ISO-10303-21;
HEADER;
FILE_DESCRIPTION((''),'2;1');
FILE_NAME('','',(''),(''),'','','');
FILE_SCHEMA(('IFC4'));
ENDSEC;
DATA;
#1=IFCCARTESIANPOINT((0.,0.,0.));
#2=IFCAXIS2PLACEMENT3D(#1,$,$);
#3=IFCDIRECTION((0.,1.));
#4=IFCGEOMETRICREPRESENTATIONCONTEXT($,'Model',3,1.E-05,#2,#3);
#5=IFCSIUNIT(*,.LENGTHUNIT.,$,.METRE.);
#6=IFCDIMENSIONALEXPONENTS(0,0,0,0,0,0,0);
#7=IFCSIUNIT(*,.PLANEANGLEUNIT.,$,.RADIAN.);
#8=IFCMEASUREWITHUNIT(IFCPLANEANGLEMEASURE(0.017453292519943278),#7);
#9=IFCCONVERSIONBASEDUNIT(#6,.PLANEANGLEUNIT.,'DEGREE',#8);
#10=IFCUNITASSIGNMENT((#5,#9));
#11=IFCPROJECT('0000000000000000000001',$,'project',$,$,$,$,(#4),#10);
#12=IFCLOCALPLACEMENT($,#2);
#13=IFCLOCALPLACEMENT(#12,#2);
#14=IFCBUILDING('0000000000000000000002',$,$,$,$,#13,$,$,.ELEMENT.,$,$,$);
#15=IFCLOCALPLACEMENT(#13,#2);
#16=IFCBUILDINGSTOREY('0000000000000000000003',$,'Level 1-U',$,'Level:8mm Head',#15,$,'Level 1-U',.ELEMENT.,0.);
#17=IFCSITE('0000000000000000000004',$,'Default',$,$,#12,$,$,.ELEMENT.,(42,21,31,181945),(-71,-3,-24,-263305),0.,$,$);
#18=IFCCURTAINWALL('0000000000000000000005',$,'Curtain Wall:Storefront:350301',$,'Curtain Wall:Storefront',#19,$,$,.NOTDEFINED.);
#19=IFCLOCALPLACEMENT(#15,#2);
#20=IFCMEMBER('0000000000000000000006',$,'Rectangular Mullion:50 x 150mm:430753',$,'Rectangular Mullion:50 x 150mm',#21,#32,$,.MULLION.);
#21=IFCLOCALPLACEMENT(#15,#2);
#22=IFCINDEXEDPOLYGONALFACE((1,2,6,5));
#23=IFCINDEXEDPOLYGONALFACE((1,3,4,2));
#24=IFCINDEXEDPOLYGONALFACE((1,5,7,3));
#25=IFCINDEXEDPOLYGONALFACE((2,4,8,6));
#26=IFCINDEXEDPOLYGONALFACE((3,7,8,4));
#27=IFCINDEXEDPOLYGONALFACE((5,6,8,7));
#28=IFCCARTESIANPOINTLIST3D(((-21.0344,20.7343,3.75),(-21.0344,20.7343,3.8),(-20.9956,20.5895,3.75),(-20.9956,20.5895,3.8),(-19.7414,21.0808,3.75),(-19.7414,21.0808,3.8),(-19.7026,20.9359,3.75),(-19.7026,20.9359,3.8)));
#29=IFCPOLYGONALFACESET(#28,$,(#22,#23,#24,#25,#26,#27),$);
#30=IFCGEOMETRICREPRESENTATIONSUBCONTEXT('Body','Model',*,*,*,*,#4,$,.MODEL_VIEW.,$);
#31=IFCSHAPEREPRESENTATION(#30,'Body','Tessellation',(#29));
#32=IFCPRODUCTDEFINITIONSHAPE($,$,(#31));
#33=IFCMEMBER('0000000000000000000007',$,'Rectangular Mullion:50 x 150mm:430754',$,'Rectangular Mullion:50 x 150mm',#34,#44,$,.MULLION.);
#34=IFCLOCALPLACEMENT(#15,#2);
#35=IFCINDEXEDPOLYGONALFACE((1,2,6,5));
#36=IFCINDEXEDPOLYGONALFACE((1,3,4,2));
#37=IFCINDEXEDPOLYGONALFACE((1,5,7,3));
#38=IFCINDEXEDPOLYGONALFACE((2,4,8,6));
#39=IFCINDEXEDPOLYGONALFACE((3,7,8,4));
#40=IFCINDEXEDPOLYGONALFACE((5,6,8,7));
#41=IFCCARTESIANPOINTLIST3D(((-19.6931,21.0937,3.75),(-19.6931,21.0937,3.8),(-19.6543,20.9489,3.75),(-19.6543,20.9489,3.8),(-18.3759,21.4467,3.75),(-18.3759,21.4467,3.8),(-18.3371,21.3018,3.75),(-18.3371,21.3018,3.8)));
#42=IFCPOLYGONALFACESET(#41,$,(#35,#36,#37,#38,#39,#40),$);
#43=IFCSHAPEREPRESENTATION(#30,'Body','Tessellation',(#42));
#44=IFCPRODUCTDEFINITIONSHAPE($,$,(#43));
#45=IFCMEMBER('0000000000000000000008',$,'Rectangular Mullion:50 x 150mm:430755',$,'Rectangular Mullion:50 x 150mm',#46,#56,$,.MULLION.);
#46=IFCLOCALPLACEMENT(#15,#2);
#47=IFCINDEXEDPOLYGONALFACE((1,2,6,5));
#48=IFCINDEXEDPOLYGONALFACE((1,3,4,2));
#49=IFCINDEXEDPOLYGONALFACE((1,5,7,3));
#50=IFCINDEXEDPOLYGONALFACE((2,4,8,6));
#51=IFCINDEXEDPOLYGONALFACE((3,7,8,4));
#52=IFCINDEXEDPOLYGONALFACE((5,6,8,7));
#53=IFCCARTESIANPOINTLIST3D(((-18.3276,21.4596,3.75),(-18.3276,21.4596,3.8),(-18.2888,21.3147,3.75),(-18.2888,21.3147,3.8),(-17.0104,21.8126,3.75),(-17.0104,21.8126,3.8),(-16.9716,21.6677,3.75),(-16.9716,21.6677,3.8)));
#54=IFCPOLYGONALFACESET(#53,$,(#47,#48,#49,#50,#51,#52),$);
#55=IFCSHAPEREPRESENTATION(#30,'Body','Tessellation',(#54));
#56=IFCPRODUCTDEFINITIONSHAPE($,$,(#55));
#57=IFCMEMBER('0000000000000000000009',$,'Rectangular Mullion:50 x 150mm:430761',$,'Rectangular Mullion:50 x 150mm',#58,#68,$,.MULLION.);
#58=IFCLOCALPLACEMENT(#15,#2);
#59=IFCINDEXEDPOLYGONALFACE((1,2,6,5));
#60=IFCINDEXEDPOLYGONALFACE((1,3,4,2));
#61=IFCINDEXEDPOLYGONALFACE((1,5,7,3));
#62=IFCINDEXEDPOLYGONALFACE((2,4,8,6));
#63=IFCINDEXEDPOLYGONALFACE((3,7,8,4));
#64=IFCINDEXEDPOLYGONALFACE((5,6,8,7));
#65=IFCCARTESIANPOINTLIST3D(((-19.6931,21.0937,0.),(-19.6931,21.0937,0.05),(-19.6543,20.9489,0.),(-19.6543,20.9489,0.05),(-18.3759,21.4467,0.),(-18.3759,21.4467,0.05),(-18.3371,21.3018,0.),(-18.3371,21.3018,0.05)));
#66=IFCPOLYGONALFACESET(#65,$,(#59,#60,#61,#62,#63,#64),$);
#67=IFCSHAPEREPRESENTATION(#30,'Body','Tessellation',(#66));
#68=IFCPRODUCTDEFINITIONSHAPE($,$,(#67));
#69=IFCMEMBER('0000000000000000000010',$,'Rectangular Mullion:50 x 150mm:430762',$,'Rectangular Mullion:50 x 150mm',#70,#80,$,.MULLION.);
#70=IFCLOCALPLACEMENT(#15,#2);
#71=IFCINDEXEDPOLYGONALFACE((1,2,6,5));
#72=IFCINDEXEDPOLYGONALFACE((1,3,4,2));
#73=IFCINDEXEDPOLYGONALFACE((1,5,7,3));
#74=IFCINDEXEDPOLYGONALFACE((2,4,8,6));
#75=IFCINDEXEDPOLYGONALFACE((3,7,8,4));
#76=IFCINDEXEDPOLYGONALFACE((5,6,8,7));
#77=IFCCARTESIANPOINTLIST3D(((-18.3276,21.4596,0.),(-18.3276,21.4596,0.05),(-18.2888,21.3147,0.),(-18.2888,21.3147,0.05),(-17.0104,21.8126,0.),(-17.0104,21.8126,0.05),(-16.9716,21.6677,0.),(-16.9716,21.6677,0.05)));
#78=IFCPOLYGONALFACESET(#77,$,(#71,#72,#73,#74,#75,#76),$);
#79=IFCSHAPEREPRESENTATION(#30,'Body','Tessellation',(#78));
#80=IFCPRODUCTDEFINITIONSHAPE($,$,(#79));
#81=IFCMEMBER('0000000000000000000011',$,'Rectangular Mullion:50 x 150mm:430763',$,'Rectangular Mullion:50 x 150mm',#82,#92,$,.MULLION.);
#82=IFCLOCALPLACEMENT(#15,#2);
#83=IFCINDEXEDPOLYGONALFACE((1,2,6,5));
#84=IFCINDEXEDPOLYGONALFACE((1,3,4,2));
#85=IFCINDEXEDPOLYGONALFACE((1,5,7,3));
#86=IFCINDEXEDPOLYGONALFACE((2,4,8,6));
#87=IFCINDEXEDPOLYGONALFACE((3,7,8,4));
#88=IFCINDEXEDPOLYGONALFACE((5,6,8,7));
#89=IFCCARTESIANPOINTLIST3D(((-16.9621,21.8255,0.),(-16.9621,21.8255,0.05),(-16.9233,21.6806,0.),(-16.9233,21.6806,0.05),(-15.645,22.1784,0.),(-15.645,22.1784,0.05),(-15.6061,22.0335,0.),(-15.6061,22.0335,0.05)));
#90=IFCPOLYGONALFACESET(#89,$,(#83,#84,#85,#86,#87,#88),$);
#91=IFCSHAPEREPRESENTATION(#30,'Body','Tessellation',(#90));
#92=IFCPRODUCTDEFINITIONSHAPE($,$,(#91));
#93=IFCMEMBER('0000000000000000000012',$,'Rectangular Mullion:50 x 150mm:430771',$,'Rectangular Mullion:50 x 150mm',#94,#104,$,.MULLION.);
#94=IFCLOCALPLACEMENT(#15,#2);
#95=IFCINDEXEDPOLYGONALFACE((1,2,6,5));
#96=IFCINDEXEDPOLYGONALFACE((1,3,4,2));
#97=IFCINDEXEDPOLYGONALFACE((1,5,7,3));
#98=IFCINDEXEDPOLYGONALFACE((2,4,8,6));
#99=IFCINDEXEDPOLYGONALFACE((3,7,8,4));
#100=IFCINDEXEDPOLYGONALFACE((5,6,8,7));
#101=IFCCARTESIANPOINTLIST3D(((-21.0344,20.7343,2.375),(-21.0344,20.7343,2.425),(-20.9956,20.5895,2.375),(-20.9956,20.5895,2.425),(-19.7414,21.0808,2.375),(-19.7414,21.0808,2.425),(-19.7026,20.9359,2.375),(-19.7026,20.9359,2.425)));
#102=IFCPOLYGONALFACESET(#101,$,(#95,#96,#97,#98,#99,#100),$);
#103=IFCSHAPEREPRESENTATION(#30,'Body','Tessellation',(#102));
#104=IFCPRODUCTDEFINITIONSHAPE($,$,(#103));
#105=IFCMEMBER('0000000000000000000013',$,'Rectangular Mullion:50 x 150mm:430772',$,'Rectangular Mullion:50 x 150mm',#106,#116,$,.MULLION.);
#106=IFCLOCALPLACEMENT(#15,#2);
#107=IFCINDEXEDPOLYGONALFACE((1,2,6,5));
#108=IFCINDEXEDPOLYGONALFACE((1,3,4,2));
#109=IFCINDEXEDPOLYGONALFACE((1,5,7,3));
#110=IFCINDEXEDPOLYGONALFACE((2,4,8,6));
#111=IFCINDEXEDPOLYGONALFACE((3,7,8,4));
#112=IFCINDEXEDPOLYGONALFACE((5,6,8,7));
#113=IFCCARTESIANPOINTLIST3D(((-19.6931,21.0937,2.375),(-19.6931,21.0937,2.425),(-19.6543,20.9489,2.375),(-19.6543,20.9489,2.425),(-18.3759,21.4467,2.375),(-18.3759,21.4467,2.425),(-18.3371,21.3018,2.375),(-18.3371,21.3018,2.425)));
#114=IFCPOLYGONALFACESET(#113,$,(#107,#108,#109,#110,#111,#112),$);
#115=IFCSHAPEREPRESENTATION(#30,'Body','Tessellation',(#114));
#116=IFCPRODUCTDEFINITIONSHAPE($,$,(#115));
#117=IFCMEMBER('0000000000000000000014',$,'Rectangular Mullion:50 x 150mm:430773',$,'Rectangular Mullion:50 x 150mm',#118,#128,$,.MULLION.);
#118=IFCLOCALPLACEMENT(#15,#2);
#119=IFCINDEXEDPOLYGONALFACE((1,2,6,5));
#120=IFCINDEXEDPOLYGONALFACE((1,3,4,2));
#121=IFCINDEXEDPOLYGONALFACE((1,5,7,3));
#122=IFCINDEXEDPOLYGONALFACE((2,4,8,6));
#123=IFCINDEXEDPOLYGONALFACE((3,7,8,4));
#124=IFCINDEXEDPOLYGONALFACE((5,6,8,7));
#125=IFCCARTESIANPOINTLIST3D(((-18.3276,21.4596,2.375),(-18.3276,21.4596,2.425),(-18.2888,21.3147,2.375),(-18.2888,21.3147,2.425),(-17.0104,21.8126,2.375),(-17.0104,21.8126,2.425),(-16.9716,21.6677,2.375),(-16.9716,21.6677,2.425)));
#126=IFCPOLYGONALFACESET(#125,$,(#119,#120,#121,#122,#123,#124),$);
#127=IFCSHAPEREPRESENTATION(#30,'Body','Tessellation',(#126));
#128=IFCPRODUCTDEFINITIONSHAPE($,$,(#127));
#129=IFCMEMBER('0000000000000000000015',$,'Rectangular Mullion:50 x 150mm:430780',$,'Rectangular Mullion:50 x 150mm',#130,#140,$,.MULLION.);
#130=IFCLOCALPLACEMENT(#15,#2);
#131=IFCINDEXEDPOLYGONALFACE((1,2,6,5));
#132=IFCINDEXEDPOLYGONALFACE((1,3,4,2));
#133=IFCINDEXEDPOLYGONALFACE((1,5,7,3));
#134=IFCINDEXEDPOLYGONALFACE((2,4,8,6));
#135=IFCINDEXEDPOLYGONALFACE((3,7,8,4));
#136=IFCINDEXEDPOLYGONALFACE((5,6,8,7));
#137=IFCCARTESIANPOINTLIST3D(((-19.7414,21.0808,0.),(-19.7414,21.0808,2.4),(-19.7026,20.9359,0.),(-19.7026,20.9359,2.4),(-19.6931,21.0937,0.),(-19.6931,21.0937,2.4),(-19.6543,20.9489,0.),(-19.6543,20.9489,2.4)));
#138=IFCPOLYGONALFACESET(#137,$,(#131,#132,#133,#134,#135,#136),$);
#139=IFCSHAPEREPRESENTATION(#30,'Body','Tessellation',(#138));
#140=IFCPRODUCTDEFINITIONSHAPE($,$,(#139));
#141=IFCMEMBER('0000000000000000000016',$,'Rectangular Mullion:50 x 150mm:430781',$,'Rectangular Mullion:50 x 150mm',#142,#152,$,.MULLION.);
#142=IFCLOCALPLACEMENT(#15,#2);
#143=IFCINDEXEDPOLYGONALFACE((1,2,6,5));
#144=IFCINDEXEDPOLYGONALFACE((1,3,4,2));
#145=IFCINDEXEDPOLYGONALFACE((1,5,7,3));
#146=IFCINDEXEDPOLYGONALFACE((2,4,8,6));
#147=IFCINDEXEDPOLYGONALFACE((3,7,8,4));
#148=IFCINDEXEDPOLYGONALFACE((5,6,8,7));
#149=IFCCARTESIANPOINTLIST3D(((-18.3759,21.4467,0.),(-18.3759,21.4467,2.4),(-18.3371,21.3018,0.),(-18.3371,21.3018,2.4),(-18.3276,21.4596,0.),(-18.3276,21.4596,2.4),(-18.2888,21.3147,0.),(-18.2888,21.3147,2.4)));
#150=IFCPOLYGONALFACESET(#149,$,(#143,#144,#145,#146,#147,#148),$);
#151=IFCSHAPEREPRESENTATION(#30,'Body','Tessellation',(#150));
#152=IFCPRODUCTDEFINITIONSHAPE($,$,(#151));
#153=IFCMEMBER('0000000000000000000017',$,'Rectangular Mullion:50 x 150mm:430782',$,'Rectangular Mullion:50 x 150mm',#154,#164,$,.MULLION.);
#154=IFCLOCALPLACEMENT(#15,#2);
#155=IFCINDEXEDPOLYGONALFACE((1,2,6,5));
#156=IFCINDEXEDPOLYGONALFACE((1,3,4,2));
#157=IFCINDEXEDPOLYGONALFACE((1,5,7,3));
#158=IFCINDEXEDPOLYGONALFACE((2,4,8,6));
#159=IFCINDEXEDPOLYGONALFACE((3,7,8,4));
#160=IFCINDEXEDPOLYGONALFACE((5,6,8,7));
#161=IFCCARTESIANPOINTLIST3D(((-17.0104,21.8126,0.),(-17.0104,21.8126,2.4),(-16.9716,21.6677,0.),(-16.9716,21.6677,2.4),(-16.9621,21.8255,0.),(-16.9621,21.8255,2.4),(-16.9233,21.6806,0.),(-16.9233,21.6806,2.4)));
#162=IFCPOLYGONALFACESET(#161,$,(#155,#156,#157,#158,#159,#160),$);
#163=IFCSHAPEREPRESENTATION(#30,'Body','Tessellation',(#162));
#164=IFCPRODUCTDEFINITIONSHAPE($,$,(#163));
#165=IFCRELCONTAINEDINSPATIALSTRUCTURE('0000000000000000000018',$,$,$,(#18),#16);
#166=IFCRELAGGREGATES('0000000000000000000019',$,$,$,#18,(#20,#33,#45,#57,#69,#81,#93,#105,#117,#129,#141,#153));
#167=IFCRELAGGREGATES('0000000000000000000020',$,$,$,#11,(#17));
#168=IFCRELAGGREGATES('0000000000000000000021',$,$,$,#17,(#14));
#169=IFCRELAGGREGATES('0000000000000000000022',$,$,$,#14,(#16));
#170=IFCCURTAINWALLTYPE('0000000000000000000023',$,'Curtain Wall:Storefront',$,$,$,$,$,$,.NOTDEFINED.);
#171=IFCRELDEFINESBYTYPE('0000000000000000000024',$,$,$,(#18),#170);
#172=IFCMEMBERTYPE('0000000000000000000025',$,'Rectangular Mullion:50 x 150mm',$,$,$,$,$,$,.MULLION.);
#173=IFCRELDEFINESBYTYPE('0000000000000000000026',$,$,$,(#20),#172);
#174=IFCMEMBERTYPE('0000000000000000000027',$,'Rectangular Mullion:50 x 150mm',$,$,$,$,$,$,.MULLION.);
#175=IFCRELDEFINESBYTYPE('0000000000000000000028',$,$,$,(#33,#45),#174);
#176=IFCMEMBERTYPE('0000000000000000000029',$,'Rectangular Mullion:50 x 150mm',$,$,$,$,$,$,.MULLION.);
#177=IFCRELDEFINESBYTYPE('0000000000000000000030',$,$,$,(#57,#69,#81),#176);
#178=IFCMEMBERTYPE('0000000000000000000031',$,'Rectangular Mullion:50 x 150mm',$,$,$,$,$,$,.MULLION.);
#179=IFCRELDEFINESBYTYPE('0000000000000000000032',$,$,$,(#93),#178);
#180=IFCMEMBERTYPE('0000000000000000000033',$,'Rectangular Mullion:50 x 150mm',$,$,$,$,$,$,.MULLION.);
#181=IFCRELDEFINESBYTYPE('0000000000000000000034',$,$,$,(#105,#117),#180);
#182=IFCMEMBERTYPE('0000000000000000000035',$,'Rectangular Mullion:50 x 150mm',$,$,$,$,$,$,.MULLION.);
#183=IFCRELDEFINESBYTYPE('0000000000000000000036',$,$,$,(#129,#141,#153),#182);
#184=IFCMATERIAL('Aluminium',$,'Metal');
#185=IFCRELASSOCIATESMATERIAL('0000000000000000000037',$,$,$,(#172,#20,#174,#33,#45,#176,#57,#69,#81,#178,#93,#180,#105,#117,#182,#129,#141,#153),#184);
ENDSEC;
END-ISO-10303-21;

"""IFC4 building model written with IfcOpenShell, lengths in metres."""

from ifc_helpers import new_model, entity, si_unit, converted_unit, direction, frame, origin, place, context, subcontext, project, spatial, indexed_curve, outline, extrude, source, transform, mapped, material, type_object, type_shapes, element, aggregate, save


model = new_model("IFC4")

# Units and contexts
model_context = context("Model", 3, precision=1e-05, world=origin(), true_north=direction((0.0, 1.0)))
body_context = subcontext(model_context, "Body", "Model", "MODEL_VIEW")
ifc_project = project(units=[si_unit("LENGTHUNIT", "METRE"), converted_unit("PLANEANGLEUNIT", "DEGREE", entity("IfcPlaneAngleMeasure", 0.017453292519943278), si_unit("PLANEANGLEUNIT", "RADIAN"), dimensions=[0, 0, 0, 0, 0, 0, 0])], contexts=[model_context])

# Site, building, storey
site_placement = place(None, origin())
site = spatial("IfcSite", under=ifc_project, at=site_placement, Name="Default", CompositionType="ELEMENT", RefLatitude=(42, 21, 31, 181945), RefLongitude=(-71, -3, -24, -263305), RefElevation=0.0)
building_placement = place(site_placement, origin())
building = spatial("IfcBuilding", under=site, at=building_placement, CompositionType="ELEMENT")
storey_placement = place(building_placement, origin())
storey = spatial("IfcBuildingStorey", under=building, at=storey_placement, Name="Level 1-U", ObjectType="Level:8mm Head", LongName="Level 1-U", CompositionType="ELEMENT", Elevation=0.0)

# Curtain wall, members
curtain_wall_type = type_object("IfcCurtainWallType", Name="Curtain Wall:Storefront", PredefinedType="NOTDEFINED")
curtain_wall_placement = place(storey_placement, origin())
curtain_wall = element("IfcCurtainWall", 1, at=curtain_wall_placement, inside=storey, type_object=curtain_wall_type, Name="Curtain Wall:Storefront:350301", ObjectType="Curtain Wall:Storefront", PredefinedType="NOTDEFINED")
ifc_material_1 = material(Name="Aluminium", Category="Metal")
member_type_1 = type_object("IfcMemberType", Name="Rectangular Mullion:50 x 150mm", PredefinedType="MULLION", material=ifc_material_1)
shared_shape_1 = source(origin(), body_context, "Body", "SweptSolid", [
    extrude(outline(indexed_curve([(-0.025, -0.075), (0.025, -0.075), (0.025, 0.075), (-0.025, 0.075), (-0.025, -0.075)], self_intersect=False)), frame((-0.025, 0.0, -1.3386), z_axis=(0.0, 0.0, 1.0), x_axis=(-1.0, 0.0, 0.0)), (0.0, 0.0, 1.0), 1.3386),
])
type_shapes(member_type_1, [shared_shape_1])
member_1_placement = place(curtain_wall_placement, frame((-19.722, 21.0084, 3.8), z_axis=(0.965926, 0.258819, 0.0), x_axis=(0.0, 0.0, 1.0)))
member_1 = element("IfcMember", 2, at=member_1_placement, type_object=member_type_1, material=ifc_material_1, Name="Rectangular Mullion:50 x 150mm:430753", ObjectType="Rectangular Mullion:50 x 150mm", PredefinedType="MULLION", context=body_context, shape_type="MappedRepresentation", body=[
    mapped(shared_shape_1, transform((0.0, 0.0, 0.0), scale=1.0)),
])
member_type_2 = type_object("IfcMemberType", Name="Rectangular Mullion:50 x 150mm", PredefinedType="MULLION", material=ifc_material_1)
shared_shape_2 = source(origin(), body_context, "Body", "SweptSolid", [
    extrude(outline(indexed_curve([(-0.025, -0.075), (0.025, -0.075), (0.025, 0.075), (-0.025, 0.075), (-0.025, -0.075)], self_intersect=False)), frame((-0.025, 0.0, -1.3636), z_axis=(0.0, 0.0, 1.0), x_axis=(-1.0, 0.0, 0.0)), (0.0, 0.0, 1.0), 1.3636),
])
type_shapes(member_type_2, [shared_shape_2])
member_2_placement = place(curtain_wall_placement, frame((-18.3565, 21.3742, 3.8), z_axis=(0.965926, 0.258819, 0.0), x_axis=(0.0, 0.0, 1.0)))
member_2 = element("IfcMember", 3, at=member_2_placement, type_object=member_type_2, material=ifc_material_1, Name="Rectangular Mullion:50 x 150mm:430754", ObjectType="Rectangular Mullion:50 x 150mm", PredefinedType="MULLION", context=body_context, shape_type="MappedRepresentation", body=[
    mapped(shared_shape_2, transform((0.0, 0.0, 0.0), scale=1.0)),
])
member_3_placement = place(curtain_wall_placement, frame((-16.991, 21.7401, 3.8), z_axis=(0.965926, 0.258819, 0.0), x_axis=(0.0, 0.0, 1.0)))
member_3 = element("IfcMember", 4, at=member_3_placement, type_object=member_type_2, material=ifc_material_1, Name="Rectangular Mullion:50 x 150mm:430755", ObjectType="Rectangular Mullion:50 x 150mm", PredefinedType="MULLION", context=body_context, shape_type="MappedRepresentation", body=[
    mapped(shared_shape_2, transform((0.0, 0.0, 0.0), scale=1.0)),
])
member_type_3 = type_object("IfcMemberType", Name="Rectangular Mullion:50 x 150mm", PredefinedType="MULLION", material=ifc_material_1)
shared_shape_3 = source(origin(), body_context, "Body", "SweptSolid", [
    extrude(outline(indexed_curve([(-0.025, -0.075), (0.025, -0.075), (0.025, 0.075), (-0.025, 0.075), (-0.025, -0.075)], self_intersect=False)), frame((-0.025, 0.0, -1.3636), z_axis=(0.0, 0.0, 1.0), x_axis=(-1.0, 0.0, 0.0)), (0.0, 0.0, 1.0), 1.3636),
])
type_shapes(member_type_3, [shared_shape_3])
member_4_placement = place(curtain_wall_placement, frame((-19.6737, 21.0213, 0.0), z_axis=(-0.965926, -0.258819, 0.0), x_axis=(0.0, 0.0, -1.0)))
member_4 = element("IfcMember", 5, at=member_4_placement, type_object=member_type_3, material=ifc_material_1, Name="Rectangular Mullion:50 x 150mm:430761", ObjectType="Rectangular Mullion:50 x 150mm", PredefinedType="MULLION", context=body_context, shape_type="MappedRepresentation", body=[
    mapped(shared_shape_3, transform((0.0, 0.0, 0.0), scale=1.0)),
])
member_5_placement = place(curtain_wall_placement, frame((-18.3082, 21.3872, 0.0), z_axis=(-0.965926, -0.258819, 0.0), x_axis=(0.0, 0.0, -1.0)))
member_5 = element("IfcMember", 6, at=member_5_placement, type_object=member_type_3, material=ifc_material_1, Name="Rectangular Mullion:50 x 150mm:430762", ObjectType="Rectangular Mullion:50 x 150mm", PredefinedType="MULLION", context=body_context, shape_type="MappedRepresentation", body=[
    mapped(shared_shape_3, transform((0.0, 0.0, 0.0), scale=1.0)),
])
member_6_placement = place(curtain_wall_placement, frame((-16.9427, 21.7531, 0.0), z_axis=(-0.965926, -0.258819, 0.0), x_axis=(0.0, 0.0, -1.0)))
member_6 = element("IfcMember", 7, at=member_6_placement, type_object=member_type_3, material=ifc_material_1, Name="Rectangular Mullion:50 x 150mm:430763", ObjectType="Rectangular Mullion:50 x 150mm", PredefinedType="MULLION", context=body_context, shape_type="MappedRepresentation", body=[
    mapped(shared_shape_3, transform((0.0, 0.0, 0.0), scale=1.0)),
])
member_type_4 = type_object("IfcMemberType", Name="Rectangular Mullion:50 x 150mm", PredefinedType="MULLION", material=ifc_material_1)
shared_shape_4 = source(origin(), body_context, "Body", "SweptSolid", [
    extrude(outline(indexed_curve([(-0.025, -0.075), (0.025, -0.075), (0.025, 0.075), (-0.025, 0.075), (-0.025, -0.075)], self_intersect=False)), frame((0.0, 0.0, -1.3386), z_axis=(0.0, 0.0, 1.0), x_axis=(-1.0, 0.0, 0.0)), (0.0, 0.0, 1.0), 1.3386),
])
type_shapes(member_type_4, [shared_shape_4])
member_7_placement = place(curtain_wall_placement, frame((-19.722, 21.0084, 2.4), z_axis=(0.965926, 0.258819, 0.0), x_axis=(0.0, 0.0, 1.0)))
member_7 = element("IfcMember", 8, at=member_7_placement, type_object=member_type_4, material=ifc_material_1, Name="Rectangular Mullion:50 x 150mm:430771", ObjectType="Rectangular Mullion:50 x 150mm", PredefinedType="MULLION", context=body_context, shape_type="MappedRepresentation", body=[
    mapped(shared_shape_4, transform((0.0, 0.0, 0.0), scale=1.0)),
])
member_type_5 = type_object("IfcMemberType", Name="Rectangular Mullion:50 x 150mm", PredefinedType="MULLION", material=ifc_material_1)
shared_shape_5 = source(origin(), body_context, "Body", "SweptSolid", [
    extrude(outline(indexed_curve([(-0.025, -0.075), (0.025, -0.075), (0.025, 0.075), (-0.025, 0.075), (-0.025, -0.075)], self_intersect=False)), frame((0.0, 0.0, -1.3636), z_axis=(0.0, 0.0, 1.0), x_axis=(-1.0, 0.0, 0.0)), (0.0, 0.0, 1.0), 1.3636),
])
type_shapes(member_type_5, [shared_shape_5])
member_8_placement = place(curtain_wall_placement, frame((-18.3565, 21.3742, 2.4), z_axis=(0.965926, 0.258819, 0.0), x_axis=(0.0, 0.0, 1.0)))
member_8 = element("IfcMember", 9, at=member_8_placement, type_object=member_type_5, material=ifc_material_1, Name="Rectangular Mullion:50 x 150mm:430772", ObjectType="Rectangular Mullion:50 x 150mm", PredefinedType="MULLION", context=body_context, shape_type="MappedRepresentation", body=[
    mapped(shared_shape_5, transform((0.0, 0.0, 0.0), scale=1.0)),
])
member_9_placement = place(curtain_wall_placement, frame((-16.991, 21.7401, 2.4), z_axis=(0.965926, 0.258819, 0.0), x_axis=(0.0, 0.0, 1.0)))
member_9 = element("IfcMember", 10, at=member_9_placement, type_object=member_type_5, material=ifc_material_1, Name="Rectangular Mullion:50 x 150mm:430773", ObjectType="Rectangular Mullion:50 x 150mm", PredefinedType="MULLION", context=body_context, shape_type="MappedRepresentation", body=[
    mapped(shared_shape_5, transform((0.0, 0.0, 0.0), scale=1.0)),
])
member_type_6 = type_object("IfcMemberType", Name="Rectangular Mullion:50 x 150mm", PredefinedType="MULLION", material=ifc_material_1)
shared_shape_6 = source(origin(), body_context, "Body", "SweptSolid", [
    extrude(outline(indexed_curve([(-0.025, -0.075), (0.025, -0.075), (0.025, 0.075), (-0.025, 0.075), (-0.025, -0.075)], self_intersect=False)), frame((0.0, 0.0, -2.4), z_axis=(0.0, 0.0, 1.0), x_axis=(-1.0, 0.0, 0.0)), (0.0, 0.0, 1.0), 2.4),
])
type_shapes(member_type_6, [shared_shape_6])
member_10_placement = place(curtain_wall_placement, frame((-19.6978, 21.0148, 0.0), z_axis=(0.0, 0.0, -1.0), x_axis=(0.965926, 0.258819, 0.0)))
member_10 = element("IfcMember", 11, at=member_10_placement, type_object=member_type_6, material=ifc_material_1, Name="Rectangular Mullion:50 x 150mm:430780", ObjectType="Rectangular Mullion:50 x 150mm", PredefinedType="MULLION", context=body_context, shape_type="MappedRepresentation", body=[
    mapped(shared_shape_6, transform((0.0, 0.0, 0.0), scale=1.0)),
])
member_11_placement = place(curtain_wall_placement, frame((-18.3324, 21.3807, 0.0), z_axis=(0.0, 0.0, -1.0), x_axis=(0.965926, 0.258819, 0.0)))
member_11 = element("IfcMember", 12, at=member_11_placement, type_object=member_type_6, material=ifc_material_1, Name="Rectangular Mullion:50 x 150mm:430781", ObjectType="Rectangular Mullion:50 x 150mm", PredefinedType="MULLION", context=body_context, shape_type="MappedRepresentation", body=[
    mapped(shared_shape_6, transform((0.0, 0.0, 0.0), scale=1.0)),
])
member_12_placement = place(curtain_wall_placement, frame((-16.9669, 21.7466, 0.0), z_axis=(0.0, 0.0, -1.0), x_axis=(0.965926, 0.258819, 0.0)))
member_12 = element("IfcMember", 13, at=member_12_placement, type_object=member_type_6, material=ifc_material_1, Name="Rectangular Mullion:50 x 150mm:430782", ObjectType="Rectangular Mullion:50 x 150mm", PredefinedType="MULLION", context=body_context, shape_type="MappedRepresentation", body=[
    mapped(shared_shape_6, transform((0.0, 0.0, 0.0), scale=1.0)),
])
aggregate(curtain_wall, [member_1, member_2, member_3, member_4, member_5, member_6, member_7, member_8, member_9, member_10, member_11, member_12])

save(model, "model.ifc")
